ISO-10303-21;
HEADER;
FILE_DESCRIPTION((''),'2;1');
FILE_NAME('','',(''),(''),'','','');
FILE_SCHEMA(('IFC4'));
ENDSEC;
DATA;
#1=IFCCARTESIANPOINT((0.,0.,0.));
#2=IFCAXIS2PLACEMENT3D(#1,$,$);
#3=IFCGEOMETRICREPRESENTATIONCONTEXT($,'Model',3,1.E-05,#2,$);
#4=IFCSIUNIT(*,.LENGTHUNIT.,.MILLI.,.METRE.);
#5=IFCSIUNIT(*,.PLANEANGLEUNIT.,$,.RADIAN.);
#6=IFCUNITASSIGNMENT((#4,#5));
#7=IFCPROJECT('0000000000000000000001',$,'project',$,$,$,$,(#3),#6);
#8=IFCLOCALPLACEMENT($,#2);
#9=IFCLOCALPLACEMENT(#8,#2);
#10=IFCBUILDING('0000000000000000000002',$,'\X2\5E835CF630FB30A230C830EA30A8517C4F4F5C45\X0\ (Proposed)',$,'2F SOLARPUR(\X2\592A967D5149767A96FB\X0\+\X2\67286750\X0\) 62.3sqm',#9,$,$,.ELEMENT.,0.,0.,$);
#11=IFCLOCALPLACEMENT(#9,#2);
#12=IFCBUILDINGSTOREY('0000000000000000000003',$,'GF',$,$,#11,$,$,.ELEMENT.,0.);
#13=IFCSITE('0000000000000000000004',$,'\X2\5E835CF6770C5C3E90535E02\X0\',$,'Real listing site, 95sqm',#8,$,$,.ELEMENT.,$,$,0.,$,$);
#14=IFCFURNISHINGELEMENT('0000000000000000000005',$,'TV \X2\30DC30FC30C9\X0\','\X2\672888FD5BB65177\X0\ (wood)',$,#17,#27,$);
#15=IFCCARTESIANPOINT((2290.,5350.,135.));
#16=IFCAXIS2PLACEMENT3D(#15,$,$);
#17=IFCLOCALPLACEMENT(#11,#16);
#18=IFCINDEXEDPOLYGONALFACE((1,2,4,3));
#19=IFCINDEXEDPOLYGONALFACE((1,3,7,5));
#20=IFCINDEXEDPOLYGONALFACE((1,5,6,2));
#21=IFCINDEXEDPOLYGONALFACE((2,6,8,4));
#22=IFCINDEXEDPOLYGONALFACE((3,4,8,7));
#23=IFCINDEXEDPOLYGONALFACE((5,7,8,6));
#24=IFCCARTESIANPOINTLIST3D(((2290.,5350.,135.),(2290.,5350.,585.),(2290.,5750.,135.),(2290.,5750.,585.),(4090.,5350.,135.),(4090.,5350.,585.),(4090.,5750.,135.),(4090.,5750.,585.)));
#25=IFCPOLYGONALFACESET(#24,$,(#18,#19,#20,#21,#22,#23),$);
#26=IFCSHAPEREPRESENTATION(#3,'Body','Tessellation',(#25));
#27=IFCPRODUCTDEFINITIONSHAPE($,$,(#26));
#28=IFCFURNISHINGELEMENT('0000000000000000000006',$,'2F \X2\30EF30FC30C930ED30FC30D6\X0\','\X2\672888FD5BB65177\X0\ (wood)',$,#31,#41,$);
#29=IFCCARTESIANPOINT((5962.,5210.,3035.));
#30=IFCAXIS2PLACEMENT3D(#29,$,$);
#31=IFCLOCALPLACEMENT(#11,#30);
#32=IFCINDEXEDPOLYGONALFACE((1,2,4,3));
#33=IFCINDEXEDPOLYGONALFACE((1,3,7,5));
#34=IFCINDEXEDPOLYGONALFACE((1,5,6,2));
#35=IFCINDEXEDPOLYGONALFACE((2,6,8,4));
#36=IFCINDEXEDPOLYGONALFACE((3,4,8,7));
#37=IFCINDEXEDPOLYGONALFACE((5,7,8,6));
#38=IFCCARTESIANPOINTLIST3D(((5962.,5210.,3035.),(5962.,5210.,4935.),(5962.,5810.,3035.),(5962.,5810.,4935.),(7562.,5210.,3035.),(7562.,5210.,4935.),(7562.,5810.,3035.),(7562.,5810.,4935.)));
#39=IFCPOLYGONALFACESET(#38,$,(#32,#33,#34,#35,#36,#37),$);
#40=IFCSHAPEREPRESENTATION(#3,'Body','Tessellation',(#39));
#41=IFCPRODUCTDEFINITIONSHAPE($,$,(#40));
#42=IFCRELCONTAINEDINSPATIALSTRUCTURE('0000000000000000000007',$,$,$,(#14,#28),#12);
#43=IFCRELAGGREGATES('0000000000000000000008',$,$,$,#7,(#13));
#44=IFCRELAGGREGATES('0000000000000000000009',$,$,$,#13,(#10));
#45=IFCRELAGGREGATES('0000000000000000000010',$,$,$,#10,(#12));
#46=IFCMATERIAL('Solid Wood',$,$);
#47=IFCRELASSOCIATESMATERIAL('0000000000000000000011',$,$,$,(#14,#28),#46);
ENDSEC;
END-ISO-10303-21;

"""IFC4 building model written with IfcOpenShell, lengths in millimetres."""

from ifc_helpers import new_model, si_unit, frame, frame_2d, origin, place, context, project, spatial, rectangle, extrude, material, element, save


model = new_model("IFC4")

# Units and contexts
model_context = context("Model", 3, precision=1e-05, world=origin())
ifc_project = project(units=[si_unit("LENGTHUNIT", "METRE", prefix="MILLI"), si_unit("PLANEANGLEUNIT", "RADIAN")], contexts=[model_context])

# Site, building, storey
site_placement = place(None, origin())
site = spatial("IfcSite", under=ifc_project, at=site_placement, Name="広島県尾道市", ObjectType="Real listing site, 95sqm", CompositionType="ELEMENT", RefElevation=0.0)
building_placement = place(site_placement, origin())
building = spatial("IfcBuilding", under=site, at=building_placement, Name="広島・アトリエ兼住居 (Proposed)", ObjectType="2F SOLARPUR(太陽光発電+木材) 62.3sqm", CompositionType="ELEMENT", ElevationOfRefHeight=0.0, ElevationOfTerrain=0.0)
storey_placement = place(building_placement, origin())
storey = spatial("IfcBuildingStorey", under=building, at=storey_placement, Name="GF", CompositionType="ELEMENT", Elevation=0.0)

# Shared definitions
ifc_material_1 = material(Name="Solid Wood")

# Furnishing elements
furnishing_1_placement = place(storey_placement, frame((2290.0, 5350.0, 135.0)))
element("IfcFurnishingElement", 1, at=furnishing_1_placement, inside=storey, material=ifc_material_1, Name="TV ボード", Description="木製家具 (wood)", context=model_context, shape_type="SweptSolid", body=[
    extrude(rectangle(XDim=1800.0, YDim=400.0, at=frame_2d((900.0, 200.0))), frame((2290.0, 5350.0, 135.0)), (0.0, 0.0, 1.0), 450.0),
])
furnishing_2_placement = place(storey_placement, frame((5962.0, 5210.0, 3035.0)))
element("IfcFurnishingElement", 2, at=furnishing_2_placement, inside=storey, material=ifc_material_1, Name="2F ワードローブ", Description="木製家具 (wood)", context=model_context, shape_type="SweptSolid", body=[
    extrude(rectangle(XDim=1600.0, YDim=600.0, at=frame_2d((800.0, 300.0))), frame((5962.0, 5210.0, 3035.0)), (0.0, 0.0, 1.0), 1900.0),
])

save(model, "model.ifc")
